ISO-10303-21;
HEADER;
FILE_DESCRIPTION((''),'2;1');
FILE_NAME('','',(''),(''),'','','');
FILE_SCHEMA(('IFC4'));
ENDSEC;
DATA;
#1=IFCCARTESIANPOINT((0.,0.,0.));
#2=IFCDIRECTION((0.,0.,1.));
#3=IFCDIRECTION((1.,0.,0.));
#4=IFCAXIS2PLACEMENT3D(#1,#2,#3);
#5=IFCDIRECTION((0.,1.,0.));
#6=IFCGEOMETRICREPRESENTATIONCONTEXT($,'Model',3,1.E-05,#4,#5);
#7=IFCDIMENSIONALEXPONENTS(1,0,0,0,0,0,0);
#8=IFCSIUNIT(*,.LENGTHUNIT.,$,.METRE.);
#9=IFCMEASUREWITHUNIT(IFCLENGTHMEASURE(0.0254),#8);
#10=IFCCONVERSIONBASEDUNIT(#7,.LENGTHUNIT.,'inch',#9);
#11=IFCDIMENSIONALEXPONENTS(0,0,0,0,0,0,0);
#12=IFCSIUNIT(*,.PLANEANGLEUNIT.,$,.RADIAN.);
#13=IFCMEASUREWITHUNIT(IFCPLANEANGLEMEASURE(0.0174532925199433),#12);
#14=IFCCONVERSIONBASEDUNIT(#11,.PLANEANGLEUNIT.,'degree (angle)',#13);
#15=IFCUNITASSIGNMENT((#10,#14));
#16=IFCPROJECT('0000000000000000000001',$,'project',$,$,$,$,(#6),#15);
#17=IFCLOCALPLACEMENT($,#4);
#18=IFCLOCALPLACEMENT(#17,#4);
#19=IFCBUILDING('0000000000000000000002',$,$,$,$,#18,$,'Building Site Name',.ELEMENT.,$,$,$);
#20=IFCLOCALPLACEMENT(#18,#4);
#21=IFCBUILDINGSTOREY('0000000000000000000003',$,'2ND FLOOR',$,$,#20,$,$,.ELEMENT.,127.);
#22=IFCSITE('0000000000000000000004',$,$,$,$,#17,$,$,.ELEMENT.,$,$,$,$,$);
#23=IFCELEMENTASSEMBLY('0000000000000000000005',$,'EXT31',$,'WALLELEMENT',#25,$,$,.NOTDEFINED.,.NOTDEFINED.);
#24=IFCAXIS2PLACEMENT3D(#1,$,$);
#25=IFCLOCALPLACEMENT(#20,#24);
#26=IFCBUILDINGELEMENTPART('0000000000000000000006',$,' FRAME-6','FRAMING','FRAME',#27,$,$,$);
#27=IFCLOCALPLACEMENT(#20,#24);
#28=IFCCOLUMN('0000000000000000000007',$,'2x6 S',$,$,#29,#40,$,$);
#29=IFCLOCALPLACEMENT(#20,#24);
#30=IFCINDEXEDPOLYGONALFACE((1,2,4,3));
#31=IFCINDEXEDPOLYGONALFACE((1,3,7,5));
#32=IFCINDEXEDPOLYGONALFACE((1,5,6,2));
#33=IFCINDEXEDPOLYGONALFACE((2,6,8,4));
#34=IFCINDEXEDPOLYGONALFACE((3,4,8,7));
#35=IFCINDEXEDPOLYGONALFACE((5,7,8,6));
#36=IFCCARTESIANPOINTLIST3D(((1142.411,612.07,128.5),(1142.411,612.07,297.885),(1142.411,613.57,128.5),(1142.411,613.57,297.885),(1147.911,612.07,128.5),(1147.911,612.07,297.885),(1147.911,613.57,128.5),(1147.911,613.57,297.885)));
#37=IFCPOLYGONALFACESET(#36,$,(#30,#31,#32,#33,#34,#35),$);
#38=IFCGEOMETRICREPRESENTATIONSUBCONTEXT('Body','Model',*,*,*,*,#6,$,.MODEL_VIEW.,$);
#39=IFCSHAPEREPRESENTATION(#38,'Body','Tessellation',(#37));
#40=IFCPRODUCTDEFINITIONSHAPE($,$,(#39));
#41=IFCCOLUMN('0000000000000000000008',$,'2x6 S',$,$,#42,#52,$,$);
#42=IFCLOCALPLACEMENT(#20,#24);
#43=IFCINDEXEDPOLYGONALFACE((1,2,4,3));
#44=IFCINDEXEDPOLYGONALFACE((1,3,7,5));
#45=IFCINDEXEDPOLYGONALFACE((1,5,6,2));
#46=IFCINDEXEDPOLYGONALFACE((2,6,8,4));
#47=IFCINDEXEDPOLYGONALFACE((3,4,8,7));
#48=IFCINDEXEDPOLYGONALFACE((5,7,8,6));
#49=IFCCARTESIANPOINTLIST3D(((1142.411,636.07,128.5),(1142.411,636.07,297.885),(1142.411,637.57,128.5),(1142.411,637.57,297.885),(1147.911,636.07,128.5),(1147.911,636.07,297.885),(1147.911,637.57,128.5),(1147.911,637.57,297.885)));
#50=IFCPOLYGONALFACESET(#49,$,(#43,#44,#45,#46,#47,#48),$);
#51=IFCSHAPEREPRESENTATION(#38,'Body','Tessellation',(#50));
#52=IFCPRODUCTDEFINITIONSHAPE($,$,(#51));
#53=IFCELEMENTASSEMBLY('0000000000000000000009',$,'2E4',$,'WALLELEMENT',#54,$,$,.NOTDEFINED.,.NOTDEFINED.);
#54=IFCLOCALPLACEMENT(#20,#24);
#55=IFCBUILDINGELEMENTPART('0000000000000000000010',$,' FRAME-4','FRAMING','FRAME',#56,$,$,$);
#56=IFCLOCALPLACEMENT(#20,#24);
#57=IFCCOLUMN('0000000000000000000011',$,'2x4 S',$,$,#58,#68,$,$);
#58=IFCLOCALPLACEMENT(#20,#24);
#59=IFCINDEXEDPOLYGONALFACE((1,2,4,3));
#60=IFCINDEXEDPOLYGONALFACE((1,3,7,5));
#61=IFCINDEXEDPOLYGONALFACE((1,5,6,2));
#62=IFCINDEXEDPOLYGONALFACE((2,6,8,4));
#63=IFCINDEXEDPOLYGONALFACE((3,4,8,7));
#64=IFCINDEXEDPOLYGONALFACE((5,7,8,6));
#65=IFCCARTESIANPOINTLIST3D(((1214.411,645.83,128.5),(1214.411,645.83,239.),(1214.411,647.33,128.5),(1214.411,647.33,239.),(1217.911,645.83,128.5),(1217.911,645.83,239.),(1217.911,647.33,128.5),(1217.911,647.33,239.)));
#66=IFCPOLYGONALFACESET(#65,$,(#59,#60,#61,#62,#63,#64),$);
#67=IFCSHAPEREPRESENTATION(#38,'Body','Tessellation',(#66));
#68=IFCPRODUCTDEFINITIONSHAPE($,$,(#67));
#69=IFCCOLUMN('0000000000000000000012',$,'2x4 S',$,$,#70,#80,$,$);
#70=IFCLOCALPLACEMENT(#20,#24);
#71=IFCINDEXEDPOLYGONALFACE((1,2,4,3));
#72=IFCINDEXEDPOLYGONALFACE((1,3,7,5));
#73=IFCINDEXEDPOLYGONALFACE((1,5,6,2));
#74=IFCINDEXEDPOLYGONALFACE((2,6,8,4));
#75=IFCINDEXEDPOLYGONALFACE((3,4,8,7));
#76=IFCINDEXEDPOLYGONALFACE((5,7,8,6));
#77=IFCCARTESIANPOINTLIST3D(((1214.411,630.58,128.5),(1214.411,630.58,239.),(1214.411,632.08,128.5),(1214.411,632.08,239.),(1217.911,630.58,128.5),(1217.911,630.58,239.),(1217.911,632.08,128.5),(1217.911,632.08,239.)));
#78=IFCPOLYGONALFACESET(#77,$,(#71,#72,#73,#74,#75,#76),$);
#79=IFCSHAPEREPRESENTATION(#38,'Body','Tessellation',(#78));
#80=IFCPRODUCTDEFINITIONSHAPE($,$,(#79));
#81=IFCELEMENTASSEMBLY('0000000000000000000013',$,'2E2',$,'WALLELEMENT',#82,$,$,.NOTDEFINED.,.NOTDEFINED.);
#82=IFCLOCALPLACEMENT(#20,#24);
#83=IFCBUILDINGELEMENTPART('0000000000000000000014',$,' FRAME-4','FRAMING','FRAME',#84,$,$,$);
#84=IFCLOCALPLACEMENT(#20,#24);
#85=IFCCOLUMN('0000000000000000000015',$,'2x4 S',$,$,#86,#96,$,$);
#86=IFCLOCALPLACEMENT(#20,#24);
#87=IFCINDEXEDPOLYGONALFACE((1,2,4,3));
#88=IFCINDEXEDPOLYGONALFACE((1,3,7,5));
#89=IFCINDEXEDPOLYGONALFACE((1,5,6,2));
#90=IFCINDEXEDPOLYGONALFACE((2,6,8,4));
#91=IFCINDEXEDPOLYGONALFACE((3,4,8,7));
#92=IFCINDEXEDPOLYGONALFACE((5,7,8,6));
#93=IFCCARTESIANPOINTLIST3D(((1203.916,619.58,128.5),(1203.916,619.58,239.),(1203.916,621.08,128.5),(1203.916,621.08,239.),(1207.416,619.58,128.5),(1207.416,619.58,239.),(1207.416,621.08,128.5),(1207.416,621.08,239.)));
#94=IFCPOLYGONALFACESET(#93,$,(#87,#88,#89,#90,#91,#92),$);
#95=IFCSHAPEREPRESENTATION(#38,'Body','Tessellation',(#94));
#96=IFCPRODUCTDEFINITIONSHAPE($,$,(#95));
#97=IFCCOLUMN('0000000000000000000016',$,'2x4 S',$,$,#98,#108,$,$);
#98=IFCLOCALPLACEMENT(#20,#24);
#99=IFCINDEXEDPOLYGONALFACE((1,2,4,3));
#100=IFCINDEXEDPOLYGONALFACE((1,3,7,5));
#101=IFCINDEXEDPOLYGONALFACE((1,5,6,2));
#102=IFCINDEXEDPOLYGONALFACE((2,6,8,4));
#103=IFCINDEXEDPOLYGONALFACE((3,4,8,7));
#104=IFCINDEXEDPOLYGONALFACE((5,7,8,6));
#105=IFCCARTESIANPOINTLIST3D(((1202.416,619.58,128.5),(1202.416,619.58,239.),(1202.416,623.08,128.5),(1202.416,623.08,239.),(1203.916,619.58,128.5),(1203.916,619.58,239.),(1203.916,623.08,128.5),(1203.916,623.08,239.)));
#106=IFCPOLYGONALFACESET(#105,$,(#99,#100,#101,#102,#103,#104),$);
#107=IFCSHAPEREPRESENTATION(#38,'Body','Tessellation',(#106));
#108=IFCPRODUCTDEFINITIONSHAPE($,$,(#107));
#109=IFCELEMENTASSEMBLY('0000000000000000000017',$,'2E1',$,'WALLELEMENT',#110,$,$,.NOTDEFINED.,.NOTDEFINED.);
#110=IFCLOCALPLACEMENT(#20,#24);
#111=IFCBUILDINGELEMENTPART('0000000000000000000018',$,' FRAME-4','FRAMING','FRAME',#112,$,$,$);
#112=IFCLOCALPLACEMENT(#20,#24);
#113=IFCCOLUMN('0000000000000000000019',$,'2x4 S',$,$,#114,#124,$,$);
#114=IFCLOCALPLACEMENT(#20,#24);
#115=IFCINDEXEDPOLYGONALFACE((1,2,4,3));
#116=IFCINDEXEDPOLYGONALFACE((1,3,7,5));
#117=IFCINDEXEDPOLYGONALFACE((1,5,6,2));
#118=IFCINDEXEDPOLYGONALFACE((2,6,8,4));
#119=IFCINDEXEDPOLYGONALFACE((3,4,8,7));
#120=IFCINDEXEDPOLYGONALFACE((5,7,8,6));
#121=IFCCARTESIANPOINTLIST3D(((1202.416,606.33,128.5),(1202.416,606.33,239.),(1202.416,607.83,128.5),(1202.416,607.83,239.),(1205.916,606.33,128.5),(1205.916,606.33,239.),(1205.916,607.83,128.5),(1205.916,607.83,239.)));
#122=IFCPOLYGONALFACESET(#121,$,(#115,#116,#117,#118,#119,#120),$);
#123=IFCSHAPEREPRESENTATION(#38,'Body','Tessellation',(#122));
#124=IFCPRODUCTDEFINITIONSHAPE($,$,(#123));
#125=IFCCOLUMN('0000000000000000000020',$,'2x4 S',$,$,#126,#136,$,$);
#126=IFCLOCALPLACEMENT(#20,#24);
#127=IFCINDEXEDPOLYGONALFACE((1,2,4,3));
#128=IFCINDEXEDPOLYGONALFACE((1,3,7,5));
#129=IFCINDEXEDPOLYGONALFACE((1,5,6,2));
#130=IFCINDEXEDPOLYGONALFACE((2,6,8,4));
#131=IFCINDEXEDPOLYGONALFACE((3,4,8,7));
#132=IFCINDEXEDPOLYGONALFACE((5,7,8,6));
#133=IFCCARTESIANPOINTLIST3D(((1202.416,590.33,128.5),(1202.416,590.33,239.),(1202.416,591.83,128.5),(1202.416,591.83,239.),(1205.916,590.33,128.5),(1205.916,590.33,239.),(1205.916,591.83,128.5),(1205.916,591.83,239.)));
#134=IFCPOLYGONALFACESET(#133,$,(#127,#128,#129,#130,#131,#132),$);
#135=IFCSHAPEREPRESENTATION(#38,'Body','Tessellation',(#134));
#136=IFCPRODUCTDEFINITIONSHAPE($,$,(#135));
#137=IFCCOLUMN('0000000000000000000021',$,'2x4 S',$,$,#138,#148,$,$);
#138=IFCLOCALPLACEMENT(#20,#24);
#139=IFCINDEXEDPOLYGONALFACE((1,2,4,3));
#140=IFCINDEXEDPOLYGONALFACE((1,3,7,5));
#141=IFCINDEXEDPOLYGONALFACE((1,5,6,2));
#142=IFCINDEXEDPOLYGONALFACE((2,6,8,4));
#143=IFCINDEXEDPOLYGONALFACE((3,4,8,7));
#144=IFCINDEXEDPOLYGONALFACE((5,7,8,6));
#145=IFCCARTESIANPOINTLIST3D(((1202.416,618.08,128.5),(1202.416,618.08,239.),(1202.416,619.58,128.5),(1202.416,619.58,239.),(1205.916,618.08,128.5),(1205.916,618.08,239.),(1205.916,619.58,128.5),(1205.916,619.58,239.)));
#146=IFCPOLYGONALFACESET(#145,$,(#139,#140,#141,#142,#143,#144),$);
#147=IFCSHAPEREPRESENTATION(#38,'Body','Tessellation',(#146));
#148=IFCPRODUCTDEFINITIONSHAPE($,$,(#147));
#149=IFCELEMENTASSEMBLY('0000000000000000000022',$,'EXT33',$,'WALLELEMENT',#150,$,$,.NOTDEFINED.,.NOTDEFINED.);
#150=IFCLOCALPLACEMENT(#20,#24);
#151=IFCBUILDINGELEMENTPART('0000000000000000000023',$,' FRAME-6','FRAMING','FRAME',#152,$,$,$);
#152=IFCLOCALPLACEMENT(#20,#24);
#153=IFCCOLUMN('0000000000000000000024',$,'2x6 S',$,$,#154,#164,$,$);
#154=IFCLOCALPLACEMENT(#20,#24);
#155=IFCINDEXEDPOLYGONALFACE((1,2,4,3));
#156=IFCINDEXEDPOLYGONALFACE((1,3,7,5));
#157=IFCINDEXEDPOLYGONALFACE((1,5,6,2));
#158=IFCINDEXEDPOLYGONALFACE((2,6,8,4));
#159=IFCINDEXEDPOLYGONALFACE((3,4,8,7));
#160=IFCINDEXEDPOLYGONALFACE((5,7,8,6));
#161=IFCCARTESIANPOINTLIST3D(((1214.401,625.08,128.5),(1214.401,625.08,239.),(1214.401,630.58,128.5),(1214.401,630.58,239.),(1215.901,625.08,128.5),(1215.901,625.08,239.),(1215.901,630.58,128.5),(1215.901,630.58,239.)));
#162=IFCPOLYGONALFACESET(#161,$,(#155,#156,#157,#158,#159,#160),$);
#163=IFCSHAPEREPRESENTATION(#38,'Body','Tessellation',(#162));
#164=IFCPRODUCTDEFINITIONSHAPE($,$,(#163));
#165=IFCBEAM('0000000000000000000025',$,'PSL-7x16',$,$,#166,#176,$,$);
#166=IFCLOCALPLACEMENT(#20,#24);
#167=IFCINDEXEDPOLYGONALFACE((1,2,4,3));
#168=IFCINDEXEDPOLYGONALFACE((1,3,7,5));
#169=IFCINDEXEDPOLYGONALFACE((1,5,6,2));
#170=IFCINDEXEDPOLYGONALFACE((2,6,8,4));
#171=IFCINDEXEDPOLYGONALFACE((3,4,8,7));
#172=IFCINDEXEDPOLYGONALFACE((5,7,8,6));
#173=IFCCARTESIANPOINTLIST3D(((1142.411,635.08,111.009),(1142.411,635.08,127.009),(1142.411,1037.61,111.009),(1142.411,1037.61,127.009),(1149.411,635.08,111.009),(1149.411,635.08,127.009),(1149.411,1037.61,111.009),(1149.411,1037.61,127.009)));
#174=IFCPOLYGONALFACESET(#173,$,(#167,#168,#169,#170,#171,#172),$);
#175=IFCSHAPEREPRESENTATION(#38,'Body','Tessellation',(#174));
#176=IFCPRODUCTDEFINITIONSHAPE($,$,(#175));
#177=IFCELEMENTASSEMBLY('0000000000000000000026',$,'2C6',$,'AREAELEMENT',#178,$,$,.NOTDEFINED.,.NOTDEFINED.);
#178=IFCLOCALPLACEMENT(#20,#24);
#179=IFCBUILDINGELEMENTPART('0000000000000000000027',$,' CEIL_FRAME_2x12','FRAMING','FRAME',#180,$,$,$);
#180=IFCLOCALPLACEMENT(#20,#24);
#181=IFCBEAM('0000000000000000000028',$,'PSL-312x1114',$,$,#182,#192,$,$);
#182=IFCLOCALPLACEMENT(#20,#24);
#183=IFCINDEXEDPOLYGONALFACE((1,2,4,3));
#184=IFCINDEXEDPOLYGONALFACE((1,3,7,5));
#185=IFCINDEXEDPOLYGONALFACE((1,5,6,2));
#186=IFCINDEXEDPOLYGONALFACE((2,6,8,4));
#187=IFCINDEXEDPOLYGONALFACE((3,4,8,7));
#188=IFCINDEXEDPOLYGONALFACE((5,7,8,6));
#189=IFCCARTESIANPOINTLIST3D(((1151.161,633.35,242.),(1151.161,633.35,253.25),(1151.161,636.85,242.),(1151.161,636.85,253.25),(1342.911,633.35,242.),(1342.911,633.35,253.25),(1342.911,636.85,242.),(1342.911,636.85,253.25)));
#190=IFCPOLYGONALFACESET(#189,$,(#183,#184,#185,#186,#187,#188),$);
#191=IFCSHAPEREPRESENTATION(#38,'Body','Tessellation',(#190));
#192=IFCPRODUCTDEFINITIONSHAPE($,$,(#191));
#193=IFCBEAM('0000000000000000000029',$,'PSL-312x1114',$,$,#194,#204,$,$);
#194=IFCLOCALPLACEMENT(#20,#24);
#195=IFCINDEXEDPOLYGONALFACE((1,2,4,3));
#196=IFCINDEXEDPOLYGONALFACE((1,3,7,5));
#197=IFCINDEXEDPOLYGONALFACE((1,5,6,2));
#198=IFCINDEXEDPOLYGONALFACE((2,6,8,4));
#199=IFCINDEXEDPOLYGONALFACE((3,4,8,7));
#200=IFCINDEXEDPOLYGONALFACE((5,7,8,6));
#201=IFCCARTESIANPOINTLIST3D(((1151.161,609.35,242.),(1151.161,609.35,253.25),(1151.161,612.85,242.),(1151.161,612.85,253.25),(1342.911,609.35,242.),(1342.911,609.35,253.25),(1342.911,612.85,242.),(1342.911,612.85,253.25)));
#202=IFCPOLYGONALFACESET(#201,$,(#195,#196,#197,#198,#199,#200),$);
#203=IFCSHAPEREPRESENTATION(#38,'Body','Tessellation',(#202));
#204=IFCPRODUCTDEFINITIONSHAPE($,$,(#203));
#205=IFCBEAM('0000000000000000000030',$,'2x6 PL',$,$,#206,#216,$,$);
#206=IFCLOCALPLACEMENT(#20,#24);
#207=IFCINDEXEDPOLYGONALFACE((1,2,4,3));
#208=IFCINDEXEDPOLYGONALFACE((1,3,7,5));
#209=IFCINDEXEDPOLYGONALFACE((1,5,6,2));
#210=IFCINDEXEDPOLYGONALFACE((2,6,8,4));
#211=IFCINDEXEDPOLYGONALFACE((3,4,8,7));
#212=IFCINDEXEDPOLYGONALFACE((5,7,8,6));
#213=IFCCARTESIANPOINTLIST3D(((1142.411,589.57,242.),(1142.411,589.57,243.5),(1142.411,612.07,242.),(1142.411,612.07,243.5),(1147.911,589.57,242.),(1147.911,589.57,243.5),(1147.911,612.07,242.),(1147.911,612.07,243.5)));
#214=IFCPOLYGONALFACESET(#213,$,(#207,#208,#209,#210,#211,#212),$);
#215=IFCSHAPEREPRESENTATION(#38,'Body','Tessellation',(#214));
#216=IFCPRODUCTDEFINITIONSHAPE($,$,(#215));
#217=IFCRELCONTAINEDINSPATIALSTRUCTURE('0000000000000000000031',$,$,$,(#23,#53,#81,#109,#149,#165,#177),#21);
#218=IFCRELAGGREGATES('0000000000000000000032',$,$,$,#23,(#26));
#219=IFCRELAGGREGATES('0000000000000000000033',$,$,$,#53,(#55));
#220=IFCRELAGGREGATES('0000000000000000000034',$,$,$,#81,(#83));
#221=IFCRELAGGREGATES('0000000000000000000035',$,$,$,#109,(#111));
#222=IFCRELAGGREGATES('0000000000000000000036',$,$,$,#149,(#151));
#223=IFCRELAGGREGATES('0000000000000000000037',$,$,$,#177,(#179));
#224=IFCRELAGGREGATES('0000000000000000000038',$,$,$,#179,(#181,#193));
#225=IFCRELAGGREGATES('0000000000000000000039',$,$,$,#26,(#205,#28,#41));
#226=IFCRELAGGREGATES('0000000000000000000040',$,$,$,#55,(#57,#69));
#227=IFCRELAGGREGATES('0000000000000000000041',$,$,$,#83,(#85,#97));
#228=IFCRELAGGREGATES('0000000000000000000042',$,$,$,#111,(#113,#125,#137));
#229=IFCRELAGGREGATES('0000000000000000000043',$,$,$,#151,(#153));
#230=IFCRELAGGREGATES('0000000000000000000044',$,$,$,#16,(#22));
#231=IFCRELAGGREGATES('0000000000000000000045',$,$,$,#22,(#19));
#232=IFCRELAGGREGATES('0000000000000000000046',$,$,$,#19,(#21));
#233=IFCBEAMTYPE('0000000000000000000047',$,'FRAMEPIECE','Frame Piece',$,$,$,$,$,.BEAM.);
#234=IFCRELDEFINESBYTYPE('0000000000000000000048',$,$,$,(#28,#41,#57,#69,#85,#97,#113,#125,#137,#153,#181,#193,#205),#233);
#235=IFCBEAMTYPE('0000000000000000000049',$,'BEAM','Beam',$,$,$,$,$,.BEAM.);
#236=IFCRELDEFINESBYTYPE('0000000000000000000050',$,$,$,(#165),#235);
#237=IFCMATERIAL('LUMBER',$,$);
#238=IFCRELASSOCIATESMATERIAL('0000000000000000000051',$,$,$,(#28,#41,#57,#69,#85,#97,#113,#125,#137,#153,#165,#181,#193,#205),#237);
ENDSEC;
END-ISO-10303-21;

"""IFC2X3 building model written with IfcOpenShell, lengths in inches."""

from ifc_helpers import new_model, entity, si_unit, converted_unit, direction, frame, frame_2d, origin_with_axes, place, context, subcontext, project, spatial, rectangle, extrude, material, type_object, element, aggregate, save


model = new_model("IFC2X3")

# Units and contexts
model_context = context("Model", 3, precision=1e-05, world=origin_with_axes(), true_north=direction((0.0, 1.0, 0.0)))
body_context = subcontext(model_context, "Body", "Model", "MODEL_VIEW")
ifc_project = project(units=[converted_unit("LENGTHUNIT", "inch", entity("IfcLengthMeasure", 0.0254), si_unit("LENGTHUNIT", "METRE"), dimensions=[1, 0, 0, 0, 0, 0, 0]), converted_unit("PLANEANGLEUNIT", "degree (angle)", entity("IfcPlaneAngleMeasure", 0.0174532925199433), si_unit("PLANEANGLEUNIT", "RADIAN"), dimensions=[0, 0, 0, 0, 0, 0, 0])], contexts=[model_context])

# Site, building, storey
site_placement = place(None, origin_with_axes())
site = spatial("IfcSite", under=ifc_project, at=site_placement, CompositionType="ELEMENT")
building_placement = place(site_placement, origin_with_axes())
building = spatial("IfcBuilding", under=site, at=building_placement, LongName="Building Site Name", CompositionType="ELEMENT")
storey_placement = place(building_placement, origin_with_axes())
storey = spatial("IfcBuildingStorey", under=building, at=storey_placement, Name="2ND FLOOR", CompositionType="ELEMENT", Elevation=127.0)

# Element assemblies, building element parts, columns
assembly_1_placement = place(storey_placement, origin_with_axes())
assembly_1 = element("IfcElementAssembly", 1, at=assembly_1_placement, inside=storey, Name="EXT31", ObjectType="WALLELEMENT", AssemblyPlace="NOTDEFINED", PredefinedType="NOTDEFINED")
building_element_part_1 = element("IfcBuildingElementPart", 2, Name=" FRAME-6", Description="FRAMING", ObjectType="FRAME")
aggregate(assembly_1, [building_element_part_1])
ifc_material_1 = material(Name="LUMBER")
beam_type_1 = type_object("IfcBeamType", Name="FRAMEPIECE", Description="Frame Piece", PredefinedType="BEAM")
column_1_placement = place(assembly_1_placement, frame((1145.161, 612.82, 297.885), z_axis=(0.0, 0.0, -1.0), x_axis=(0.0, -1.0, 0.0)))
column_1 = element("IfcColumn", 3, at=column_1_placement, type_object=beam_type_1, material=ifc_material_1, Name="2x6 S", context=body_context, shape_type="SweptSolid", body=[
    extrude(rectangle(XDim=1.5, YDim=5.5, at=frame_2d((0.0, 0.0), x_axis=(-1.0, 0.0))), origin_with_axes(), (0.0, 0.0, 1.0), 169.385),
])
column_2_placement = place(assembly_1_placement, frame((1145.161, 636.82, 297.885), z_axis=(0.0, 0.0, -1.0), x_axis=(0.0, -1.0, 0.0)))
column_2 = element("IfcColumn", 4, at=column_2_placement, type_object=beam_type_1, material=ifc_material_1, Name="2x6 S", context=body_context, shape_type="SweptSolid", body=[
    extrude(rectangle(XDim=1.5, YDim=5.5, at=frame_2d((0.0, 0.0), x_axis=(-1.0, 0.0))), origin_with_axes(), (0.0, 0.0, 1.0), 169.385),
])
assembly_2_placement = place(storey_placement, origin_with_axes())
assembly_2 = element("IfcElementAssembly", 5, at=assembly_2_placement, inside=storey, Name="2E4", ObjectType="WALLELEMENT", AssemblyPlace="NOTDEFINED", PredefinedType="NOTDEFINED")
building_element_part_2 = element("IfcBuildingElementPart", 6, Name=" FRAME-4", Description="FRAMING", ObjectType="FRAME")
aggregate(assembly_2, [building_element_part_2])
column_3_placement = place(assembly_2_placement, frame((1216.161, 646.58, 239.0), z_axis=(0.0, 0.0, -1.0), x_axis=(0.0, 1.0, 0.0)))
column_3 = element("IfcColumn", 7, at=column_3_placement, type_object=beam_type_1, material=ifc_material_1, Name="2x4 S", context=body_context, shape_type="SweptSolid", body=[
    extrude(rectangle(XDim=1.5, YDim=3.5, at=frame_2d((0.0, 0.0), x_axis=(-1.0, 0.0))), origin_with_axes(), (0.0, 0.0, 1.0), 110.5),
])
column_4_placement = place(assembly_2_placement, frame((1216.161, 631.33, 239.0), z_axis=(0.0, 0.0, -1.0), x_axis=(0.0, 1.0, 0.0)))
column_4 = element("IfcColumn", 8, at=column_4_placement, type_object=beam_type_1, material=ifc_material_1, Name="2x4 S", context=body_context, shape_type="SweptSolid", body=[
    extrude(rectangle(XDim=1.5, YDim=3.5, at=frame_2d((0.0, 0.0), x_axis=(-1.0, 0.0))), origin_with_axes(), (0.0, 0.0, 1.0), 110.5),
])
assembly_3_placement = place(storey_placement, origin_with_axes())
assembly_3 = element("IfcElementAssembly", 9, at=assembly_3_placement, inside=storey, Name="2E2", ObjectType="WALLELEMENT", AssemblyPlace="NOTDEFINED", PredefinedType="NOTDEFINED")
building_element_part_3 = element("IfcBuildingElementPart", 10, Name=" FRAME-4", Description="FRAMING", ObjectType="FRAME")
aggregate(assembly_3, [building_element_part_3])
column_5_placement = place(assembly_3_placement, frame((1205.666, 620.33, 128.5), z_axis=(0.0, 0.0, 1.0), x_axis=(0.0, -1.0, 0.0)))
column_5 = element("IfcColumn", 11, at=column_5_placement, type_object=beam_type_1, material=ifc_material_1, Name="2x4 S", context=body_context, shape_type="SweptSolid", body=[
    extrude(rectangle(XDim=1.5, YDim=3.5, at=frame_2d((0.0, 0.0), x_axis=(-1.0, 0.0))), origin_with_axes(), (0.0, 0.0, 1.0), 110.5),
])
column_6_placement = place(assembly_3_placement, frame((1203.166, 621.33, 128.5), z_axis=(0.0, 0.0, 1.0), x_axis=(1.0, 0.0, 0.0)))
column_6 = element("IfcColumn", 12, at=column_6_placement, type_object=beam_type_1, material=ifc_material_1, Name="2x4 S", context=body_context, shape_type="SweptSolid", body=[
    extrude(rectangle(XDim=1.5, YDim=3.5, at=frame_2d((0.0, 0.0), x_axis=(-1.0, 0.0))), origin_with_axes(), (0.0, 0.0, 1.0), 110.5),
])
assembly_4_placement = place(storey_placement, origin_with_axes())
assembly_4 = element("IfcElementAssembly", 13, at=assembly_4_placement, inside=storey, Name="2E1", ObjectType="WALLELEMENT", AssemblyPlace="NOTDEFINED", PredefinedType="NOTDEFINED")
building_element_part_4 = element("IfcBuildingElementPart", 14, Name=" FRAME-4", Description="FRAMING", ObjectType="FRAME")
aggregate(assembly_4, [building_element_part_4])
column_7_placement = place(assembly_4_placement, frame((1204.166, 607.08, 239.0), z_axis=(0.0, 0.0, -1.0), x_axis=(0.0, -1.0, 0.0)))
column_7 = element("IfcColumn", 15, at=column_7_placement, type_object=beam_type_1, material=ifc_material_1, Name="2x4 S", context=body_context, shape_type="SweptSolid", body=[
    extrude(rectangle(XDim=1.5, YDim=3.5, at=frame_2d((0.0, 0.0), x_axis=(-1.0, 0.0))), origin_with_axes(), (0.0, 0.0, 1.0), 110.5),
])
column_8_placement = place(assembly_4_placement, frame((1204.166, 591.08, 239.0), z_axis=(0.0, 0.0, -1.0), x_axis=(0.0, -1.0, 0.0)))
column_8 = element("IfcColumn", 16, at=column_8_placement, type_object=beam_type_1, material=ifc_material_1, Name="2x4 S", context=body_context, shape_type="SweptSolid", body=[
    extrude(rectangle(XDim=1.5, YDim=3.5, at=frame_2d((0.0, 0.0), x_axis=(-1.0, 0.0))), origin_with_axes(), (0.0, 0.0, 1.0), 110.5),
])
column_9_placement = place(assembly_4_placement, frame((1204.166, 618.83, 239.0), z_axis=(0.0, 0.0, -1.0), x_axis=(0.0, -1.0, 0.0)))
column_9 = element("IfcColumn", 17, at=column_9_placement, type_object=beam_type_1, material=ifc_material_1, Name="2x4 S", context=body_context, shape_type="SweptSolid", body=[
    extrude(rectangle(XDim=1.5, YDim=3.5, at=frame_2d((0.0, 0.0), x_axis=(-1.0, 0.0))), origin_with_axes(), (0.0, 0.0, 1.0), 110.5),
])

# Element assembly, building element part, column
assembly_5_placement = place(storey_placement, origin_with_axes())
assembly_5 = element("IfcElementAssembly", 18, at=assembly_5_placement, inside=storey, Name="EXT33", ObjectType="WALLELEMENT", AssemblyPlace="NOTDEFINED", PredefinedType="NOTDEFINED")
building_element_part_5 = element("IfcBuildingElementPart", 19, Name=" FRAME-6", Description="FRAMING", ObjectType="FRAME")
aggregate(assembly_5, [building_element_part_5])
column_10_placement = place(assembly_5_placement, frame((1215.151, 627.83, 239.0), z_axis=(0.0, 0.0, -1.0), x_axis=(1.0, 0.0, 0.0)))
column_10 = element("IfcColumn", 20, at=column_10_placement, type_object=beam_type_1, material=ifc_material_1, Name="2x6 S", context=body_context, shape_type="SweptSolid", body=[
    extrude(rectangle(XDim=1.5, YDim=5.5, at=frame_2d((0.0, 0.0), x_axis=(-1.0, 0.0))), origin_with_axes(), (0.0, 0.0, 1.0), 110.5),
])

# Beam
beam_type_2 = type_object("IfcBeamType", Name="BEAM", Description="Beam", PredefinedType="BEAM")
beam_1_placement = place(storey_placement, frame((1145.911, 635.08, 119.009), z_axis=(0.0, 1.0, 0.0), x_axis=(-1.0, 0.0, 0.0)))
element("IfcBeam", 21, at=beam_1_placement, inside=storey, type_object=beam_type_2, material=ifc_material_1, Name="PSL-7x16", context=body_context, shape_type="SweptSolid", body=[
    extrude(rectangle(XDim=7.0, YDim=16.0, at=frame_2d((0.0, 0.0), x_axis=(-1.0, 0.0))), origin_with_axes(), (0.0, 0.0, 1.0), 402.53),
])

# Element assembly, building element part, beams
assembly_6_placement = place(storey_placement, origin_with_axes())
assembly_6 = element("IfcElementAssembly", 22, at=assembly_6_placement, inside=storey, Name="2C6", ObjectType="AREAELEMENT", AssemblyPlace="NOTDEFINED", PredefinedType="NOTDEFINED")
building_element_part_6 = element("IfcBuildingElementPart", 23, Name=" CEIL_FRAME_2x12", Description="FRAMING", ObjectType="FRAME")
aggregate(assembly_6, [building_element_part_6])
beam_2_placement = place(assembly_6_placement, frame((1151.161, 635.1, 247.625), z_axis=(1.0, 0.0, 0.0), x_axis=(0.0, 1.0, 0.0)))
beam_2 = element("IfcBeam", 24, at=beam_2_placement, type_object=beam_type_1, material=ifc_material_1, Name="PSL-312x1114", context=body_context, shape_type="SweptSolid", body=[
    extrude(rectangle(XDim=3.5, YDim=11.25, at=frame_2d((0.0, 0.0), x_axis=(-1.0, 0.0))), origin_with_axes(), (0.0, 0.0, 1.0), 191.75),
])
beam_3_placement = place(assembly_6_placement, frame((1151.161, 611.1, 247.625), z_axis=(1.0, 0.0, 0.0), x_axis=(0.0, 1.0, 0.0)))
beam_3 = element("IfcBeam", 25, at=beam_3_placement, type_object=beam_type_1, material=ifc_material_1, Name="PSL-312x1114", context=body_context, shape_type="SweptSolid", body=[
    extrude(rectangle(XDim=3.5, YDim=11.25, at=frame_2d((0.0, 0.0), x_axis=(-1.0, 0.0))), origin_with_axes(), (0.0, 0.0, 1.0), 191.75),
])
aggregate(building_element_part_6, [beam_2, beam_3])

# Beam
beam_4_placement = place(assembly_1_placement, frame((1145.161, 589.57, 242.75), z_axis=(0.0, 1.0, 0.0), x_axis=(0.0, 0.0, -1.0)))
beam_4 = element("IfcBeam", 26, at=beam_4_placement, type_object=beam_type_1, material=ifc_material_1, Name="2x6 PL", context=body_context, shape_type="SweptSolid", body=[
    extrude(rectangle(XDim=1.5, YDim=5.5, at=frame_2d((0.0, 0.0), x_axis=(-1.0, 0.0))), origin_with_axes(), (0.0, 0.0, 1.0), 22.5),
])
aggregate(building_element_part_1, [beam_4, column_1, column_2])
aggregate(building_element_part_2, [column_3, column_4])
aggregate(building_element_part_3, [column_5, column_6])
aggregate(building_element_part_4, [column_7, column_8, column_9])
aggregate(building_element_part_5, [column_10])

save(model, "model.ifc")
